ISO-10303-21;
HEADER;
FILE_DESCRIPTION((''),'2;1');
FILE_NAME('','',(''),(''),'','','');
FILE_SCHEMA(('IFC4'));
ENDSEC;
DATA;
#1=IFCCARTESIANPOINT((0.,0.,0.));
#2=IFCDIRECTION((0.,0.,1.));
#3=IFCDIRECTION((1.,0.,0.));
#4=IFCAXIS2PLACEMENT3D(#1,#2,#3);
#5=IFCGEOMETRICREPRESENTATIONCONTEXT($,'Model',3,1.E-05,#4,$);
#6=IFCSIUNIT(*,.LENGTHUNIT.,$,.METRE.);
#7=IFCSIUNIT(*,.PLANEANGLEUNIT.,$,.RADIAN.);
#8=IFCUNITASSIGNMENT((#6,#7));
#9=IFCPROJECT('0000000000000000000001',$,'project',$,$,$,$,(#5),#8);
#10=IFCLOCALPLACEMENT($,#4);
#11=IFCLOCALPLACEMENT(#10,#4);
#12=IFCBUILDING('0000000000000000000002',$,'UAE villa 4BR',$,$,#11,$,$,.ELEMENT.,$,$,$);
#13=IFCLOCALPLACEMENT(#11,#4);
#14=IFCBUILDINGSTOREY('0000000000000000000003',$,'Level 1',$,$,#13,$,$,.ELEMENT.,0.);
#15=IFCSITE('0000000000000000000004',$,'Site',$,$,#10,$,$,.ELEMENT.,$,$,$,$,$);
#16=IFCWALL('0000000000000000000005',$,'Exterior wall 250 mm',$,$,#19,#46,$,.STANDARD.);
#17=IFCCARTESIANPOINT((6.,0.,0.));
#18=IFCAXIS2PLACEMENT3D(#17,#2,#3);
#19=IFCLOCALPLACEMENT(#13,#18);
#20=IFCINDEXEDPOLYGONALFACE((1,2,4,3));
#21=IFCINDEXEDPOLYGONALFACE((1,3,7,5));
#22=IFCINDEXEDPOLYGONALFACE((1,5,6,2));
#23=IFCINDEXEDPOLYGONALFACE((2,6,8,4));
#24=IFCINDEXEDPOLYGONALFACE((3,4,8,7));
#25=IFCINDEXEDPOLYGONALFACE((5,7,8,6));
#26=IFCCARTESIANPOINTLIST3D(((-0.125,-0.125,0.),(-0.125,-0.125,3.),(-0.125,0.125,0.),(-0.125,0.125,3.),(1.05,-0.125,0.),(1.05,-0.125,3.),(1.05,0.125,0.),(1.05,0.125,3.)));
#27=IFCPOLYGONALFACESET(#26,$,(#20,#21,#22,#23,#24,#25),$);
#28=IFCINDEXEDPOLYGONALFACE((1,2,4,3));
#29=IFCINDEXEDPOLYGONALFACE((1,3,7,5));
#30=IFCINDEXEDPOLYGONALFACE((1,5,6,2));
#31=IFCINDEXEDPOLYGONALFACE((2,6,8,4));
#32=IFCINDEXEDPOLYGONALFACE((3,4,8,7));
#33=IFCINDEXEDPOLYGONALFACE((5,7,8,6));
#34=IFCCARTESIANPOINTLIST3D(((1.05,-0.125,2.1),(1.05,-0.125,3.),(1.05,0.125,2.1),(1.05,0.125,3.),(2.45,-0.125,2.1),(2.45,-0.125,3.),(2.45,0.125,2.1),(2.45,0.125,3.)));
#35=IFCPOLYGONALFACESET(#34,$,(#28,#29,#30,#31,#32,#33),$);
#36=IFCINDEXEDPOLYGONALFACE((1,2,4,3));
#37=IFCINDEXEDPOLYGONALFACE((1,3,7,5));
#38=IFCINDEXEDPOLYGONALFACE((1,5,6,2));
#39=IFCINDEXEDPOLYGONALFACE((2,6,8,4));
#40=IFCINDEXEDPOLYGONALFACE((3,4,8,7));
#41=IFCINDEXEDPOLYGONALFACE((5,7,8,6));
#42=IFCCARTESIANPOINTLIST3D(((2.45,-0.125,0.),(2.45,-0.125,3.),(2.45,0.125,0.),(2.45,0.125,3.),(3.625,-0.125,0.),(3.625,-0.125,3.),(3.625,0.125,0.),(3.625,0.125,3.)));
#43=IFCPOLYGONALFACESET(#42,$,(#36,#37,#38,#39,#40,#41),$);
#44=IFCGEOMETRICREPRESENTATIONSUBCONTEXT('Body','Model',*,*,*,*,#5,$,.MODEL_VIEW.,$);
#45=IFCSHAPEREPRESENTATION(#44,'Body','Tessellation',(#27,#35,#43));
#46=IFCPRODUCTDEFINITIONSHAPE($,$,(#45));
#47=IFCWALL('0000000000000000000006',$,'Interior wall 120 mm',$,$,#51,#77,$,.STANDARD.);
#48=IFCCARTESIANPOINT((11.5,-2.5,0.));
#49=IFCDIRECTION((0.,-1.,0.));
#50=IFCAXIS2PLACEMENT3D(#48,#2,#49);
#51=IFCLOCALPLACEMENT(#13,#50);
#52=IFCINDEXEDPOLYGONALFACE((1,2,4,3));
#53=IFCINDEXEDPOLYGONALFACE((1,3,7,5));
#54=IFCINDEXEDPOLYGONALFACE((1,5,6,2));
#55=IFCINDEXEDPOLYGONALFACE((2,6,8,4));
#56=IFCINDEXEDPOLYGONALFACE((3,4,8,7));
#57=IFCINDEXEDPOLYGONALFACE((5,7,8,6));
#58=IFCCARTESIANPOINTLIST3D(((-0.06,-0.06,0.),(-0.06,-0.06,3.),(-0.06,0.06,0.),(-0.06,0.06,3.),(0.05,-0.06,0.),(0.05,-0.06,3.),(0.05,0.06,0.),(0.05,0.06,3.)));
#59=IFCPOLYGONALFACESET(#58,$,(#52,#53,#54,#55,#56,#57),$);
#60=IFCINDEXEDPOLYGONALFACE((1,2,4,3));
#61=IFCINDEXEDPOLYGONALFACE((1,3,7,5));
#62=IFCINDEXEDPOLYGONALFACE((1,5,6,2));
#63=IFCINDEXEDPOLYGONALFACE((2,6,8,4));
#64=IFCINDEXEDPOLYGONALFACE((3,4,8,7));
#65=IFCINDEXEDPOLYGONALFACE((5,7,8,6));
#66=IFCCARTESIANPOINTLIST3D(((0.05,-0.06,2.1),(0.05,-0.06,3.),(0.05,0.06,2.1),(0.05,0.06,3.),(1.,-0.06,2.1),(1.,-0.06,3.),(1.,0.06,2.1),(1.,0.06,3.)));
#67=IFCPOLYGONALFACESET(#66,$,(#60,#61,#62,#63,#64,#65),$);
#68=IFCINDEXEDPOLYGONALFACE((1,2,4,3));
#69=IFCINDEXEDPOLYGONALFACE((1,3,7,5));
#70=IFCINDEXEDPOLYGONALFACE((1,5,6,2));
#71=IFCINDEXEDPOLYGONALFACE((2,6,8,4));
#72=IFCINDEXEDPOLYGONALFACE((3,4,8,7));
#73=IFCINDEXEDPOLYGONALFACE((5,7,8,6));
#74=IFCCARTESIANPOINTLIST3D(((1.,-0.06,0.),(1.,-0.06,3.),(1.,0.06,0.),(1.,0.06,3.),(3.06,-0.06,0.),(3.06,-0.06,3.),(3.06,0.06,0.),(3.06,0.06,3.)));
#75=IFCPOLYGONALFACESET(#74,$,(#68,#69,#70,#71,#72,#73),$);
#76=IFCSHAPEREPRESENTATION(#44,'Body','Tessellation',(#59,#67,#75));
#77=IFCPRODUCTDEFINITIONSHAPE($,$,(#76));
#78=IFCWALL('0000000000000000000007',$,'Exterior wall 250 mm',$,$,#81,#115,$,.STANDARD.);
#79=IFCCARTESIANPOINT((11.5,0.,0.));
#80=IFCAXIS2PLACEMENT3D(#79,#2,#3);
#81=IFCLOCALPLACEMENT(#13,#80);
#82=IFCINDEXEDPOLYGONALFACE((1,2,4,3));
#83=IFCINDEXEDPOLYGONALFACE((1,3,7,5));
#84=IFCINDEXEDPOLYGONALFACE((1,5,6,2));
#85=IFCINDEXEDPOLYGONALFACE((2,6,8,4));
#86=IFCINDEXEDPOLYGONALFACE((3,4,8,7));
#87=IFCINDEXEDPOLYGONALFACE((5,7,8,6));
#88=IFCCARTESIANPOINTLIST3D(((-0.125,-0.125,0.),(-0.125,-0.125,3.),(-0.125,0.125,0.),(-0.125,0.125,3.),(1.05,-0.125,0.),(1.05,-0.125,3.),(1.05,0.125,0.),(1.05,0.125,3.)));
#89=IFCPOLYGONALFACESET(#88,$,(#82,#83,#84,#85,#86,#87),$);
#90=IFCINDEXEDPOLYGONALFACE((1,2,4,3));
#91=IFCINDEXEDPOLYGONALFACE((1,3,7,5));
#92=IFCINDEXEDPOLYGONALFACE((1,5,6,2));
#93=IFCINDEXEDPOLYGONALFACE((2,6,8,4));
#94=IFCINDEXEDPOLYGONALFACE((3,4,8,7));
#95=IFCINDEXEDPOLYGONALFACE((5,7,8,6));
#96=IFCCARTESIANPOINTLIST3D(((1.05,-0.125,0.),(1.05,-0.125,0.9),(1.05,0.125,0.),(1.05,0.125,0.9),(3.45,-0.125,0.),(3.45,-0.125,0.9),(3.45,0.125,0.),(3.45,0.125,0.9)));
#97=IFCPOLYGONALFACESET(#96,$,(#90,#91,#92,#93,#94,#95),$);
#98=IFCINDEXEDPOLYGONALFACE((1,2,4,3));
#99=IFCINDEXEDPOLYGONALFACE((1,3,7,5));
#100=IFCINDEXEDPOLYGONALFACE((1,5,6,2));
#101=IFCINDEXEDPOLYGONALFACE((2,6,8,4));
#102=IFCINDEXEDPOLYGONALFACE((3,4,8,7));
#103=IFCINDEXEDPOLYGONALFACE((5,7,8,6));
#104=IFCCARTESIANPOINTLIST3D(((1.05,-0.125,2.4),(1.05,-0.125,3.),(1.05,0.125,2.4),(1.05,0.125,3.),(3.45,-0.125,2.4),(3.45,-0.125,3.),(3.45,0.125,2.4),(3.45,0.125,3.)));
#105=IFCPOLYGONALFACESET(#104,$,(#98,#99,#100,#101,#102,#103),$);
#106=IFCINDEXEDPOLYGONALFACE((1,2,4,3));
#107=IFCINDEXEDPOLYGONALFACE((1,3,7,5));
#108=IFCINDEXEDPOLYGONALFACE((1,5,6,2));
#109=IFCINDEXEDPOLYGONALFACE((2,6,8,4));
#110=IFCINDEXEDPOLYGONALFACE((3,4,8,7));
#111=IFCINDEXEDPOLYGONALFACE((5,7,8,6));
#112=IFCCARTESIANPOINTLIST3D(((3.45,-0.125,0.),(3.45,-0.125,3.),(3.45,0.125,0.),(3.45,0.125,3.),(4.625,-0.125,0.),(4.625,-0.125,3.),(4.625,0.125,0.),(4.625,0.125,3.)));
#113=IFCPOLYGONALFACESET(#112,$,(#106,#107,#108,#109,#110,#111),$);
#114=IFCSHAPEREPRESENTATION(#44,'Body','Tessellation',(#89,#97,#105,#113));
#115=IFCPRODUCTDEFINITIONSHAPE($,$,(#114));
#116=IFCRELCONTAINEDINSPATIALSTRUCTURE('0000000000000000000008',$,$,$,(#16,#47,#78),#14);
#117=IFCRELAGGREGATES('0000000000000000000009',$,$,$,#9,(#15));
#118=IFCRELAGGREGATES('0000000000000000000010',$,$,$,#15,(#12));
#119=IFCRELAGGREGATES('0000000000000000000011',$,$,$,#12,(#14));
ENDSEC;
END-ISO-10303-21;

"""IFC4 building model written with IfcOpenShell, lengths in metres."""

from ifc_helpers import new_model, si_unit, frame, origin_with_axes, origin_2d, place, context, subcontext, project, spatial, rectangle, extrude, element, save


model = new_model("IFC4")

# Units and contexts
model_context = context("Model", 3, precision=1e-05, world=origin_with_axes())
body_context = subcontext(model_context, "Body", "Model", "MODEL_VIEW")
ifc_project = project(units=[si_unit("LENGTHUNIT", "METRE"), si_unit("PLANEANGLEUNIT", "RADIAN")], contexts=[model_context])

# Site, building, storey
site_placement = place(None, origin_with_axes())
site = spatial("IfcSite", under=ifc_project, at=site_placement, Name="Site", CompositionType="ELEMENT")
building_placement = place(site_placement, origin_with_axes())
building = spatial("IfcBuilding", under=site, at=building_placement, Name="UAE villa 4BR", CompositionType="ELEMENT")
storey_placement = place(building_placement, origin_with_axes())
storey = spatial("IfcBuildingStorey", under=building, at=storey_placement, Name="Level 1", CompositionType="ELEMENT", Elevation=0.0)

# Walls
wall_1_placement = place(storey_placement, frame((6.0, 0.0, 0.0), z_axis=(0.0, 0.0, 1.0), x_axis=(1.0, 0.0, 0.0)))
element("IfcWall", 1, at=wall_1_placement, inside=storey, Name="Exterior wall 250 mm", PredefinedType="STANDARD", context=body_context, shape_type="SweptSolid", body=[
    extrude(rectangle(XDim=1.175, YDim=0.25, at=origin_2d()), frame((0.4625, 0.0, 0.0)), (0.0, 0.0, 1.0), 3.0),
    extrude(rectangle(XDim=1.4, YDim=0.25, at=origin_2d()), frame((1.75, 0.0, 2.1)), (0.0, 0.0, 1.0), 0.9),
    extrude(rectangle(XDim=1.175, YDim=0.25, at=origin_2d()), frame((3.0375, 0.0, 0.0)), (0.0, 0.0, 1.0), 3.0),
])
wall_2_placement = place(storey_placement, frame((11.5, -2.5, 0.0), z_axis=(0.0, 0.0, 1.0), x_axis=(0.0, -1.0, 0.0)))
element("IfcWall", 2, at=wall_2_placement, inside=storey, Name="Interior wall 120 mm", PredefinedType="STANDARD", context=body_context, shape_type="SweptSolid", body=[
    extrude(rectangle(XDim=0.11, YDim=0.12, at=origin_2d()), frame((-0.005, 0.0, 0.0)), (0.0, 0.0, 1.0), 3.0),
    extrude(rectangle(XDim=0.95, YDim=0.12, at=origin_2d()), frame((0.525, 0.0, 2.1)), (0.0, 0.0, 1.0), 0.9),
    extrude(rectangle(XDim=2.06, YDim=0.12, at=origin_2d()), frame((2.03, 0.0, 0.0)), (0.0, 0.0, 1.0), 3.0),
])
wall_3_placement = place(storey_placement, frame((11.5, 0.0, 0.0), z_axis=(0.0, 0.0, 1.0), x_axis=(1.0, 0.0, 0.0)))
element("IfcWall", 3, at=wall_3_placement, inside=storey, Name="Exterior wall 250 mm", PredefinedType="STANDARD", context=body_context, shape_type="SweptSolid", body=[
    extrude(rectangle(XDim=1.175, YDim=0.25, at=origin_2d()), frame((0.4625, 0.0, 0.0)), (0.0, 0.0, 1.0), 3.0),
    extrude(rectangle(XDim=2.4, YDim=0.25, at=origin_2d()), frame((2.25, 0.0, 0.0)), (0.0, 0.0, 1.0), 0.9),
    extrude(rectangle(XDim=2.4, YDim=0.25, at=origin_2d()), frame((2.25, 0.0, 2.4)), (0.0, 0.0, 1.0), 0.6),
    extrude(rectangle(XDim=1.175, YDim=0.25, at=origin_2d()), frame((4.0375, 0.0, 0.0)), (0.0, 0.0, 1.0), 3.0),
])

save(model, "model.ifc")
